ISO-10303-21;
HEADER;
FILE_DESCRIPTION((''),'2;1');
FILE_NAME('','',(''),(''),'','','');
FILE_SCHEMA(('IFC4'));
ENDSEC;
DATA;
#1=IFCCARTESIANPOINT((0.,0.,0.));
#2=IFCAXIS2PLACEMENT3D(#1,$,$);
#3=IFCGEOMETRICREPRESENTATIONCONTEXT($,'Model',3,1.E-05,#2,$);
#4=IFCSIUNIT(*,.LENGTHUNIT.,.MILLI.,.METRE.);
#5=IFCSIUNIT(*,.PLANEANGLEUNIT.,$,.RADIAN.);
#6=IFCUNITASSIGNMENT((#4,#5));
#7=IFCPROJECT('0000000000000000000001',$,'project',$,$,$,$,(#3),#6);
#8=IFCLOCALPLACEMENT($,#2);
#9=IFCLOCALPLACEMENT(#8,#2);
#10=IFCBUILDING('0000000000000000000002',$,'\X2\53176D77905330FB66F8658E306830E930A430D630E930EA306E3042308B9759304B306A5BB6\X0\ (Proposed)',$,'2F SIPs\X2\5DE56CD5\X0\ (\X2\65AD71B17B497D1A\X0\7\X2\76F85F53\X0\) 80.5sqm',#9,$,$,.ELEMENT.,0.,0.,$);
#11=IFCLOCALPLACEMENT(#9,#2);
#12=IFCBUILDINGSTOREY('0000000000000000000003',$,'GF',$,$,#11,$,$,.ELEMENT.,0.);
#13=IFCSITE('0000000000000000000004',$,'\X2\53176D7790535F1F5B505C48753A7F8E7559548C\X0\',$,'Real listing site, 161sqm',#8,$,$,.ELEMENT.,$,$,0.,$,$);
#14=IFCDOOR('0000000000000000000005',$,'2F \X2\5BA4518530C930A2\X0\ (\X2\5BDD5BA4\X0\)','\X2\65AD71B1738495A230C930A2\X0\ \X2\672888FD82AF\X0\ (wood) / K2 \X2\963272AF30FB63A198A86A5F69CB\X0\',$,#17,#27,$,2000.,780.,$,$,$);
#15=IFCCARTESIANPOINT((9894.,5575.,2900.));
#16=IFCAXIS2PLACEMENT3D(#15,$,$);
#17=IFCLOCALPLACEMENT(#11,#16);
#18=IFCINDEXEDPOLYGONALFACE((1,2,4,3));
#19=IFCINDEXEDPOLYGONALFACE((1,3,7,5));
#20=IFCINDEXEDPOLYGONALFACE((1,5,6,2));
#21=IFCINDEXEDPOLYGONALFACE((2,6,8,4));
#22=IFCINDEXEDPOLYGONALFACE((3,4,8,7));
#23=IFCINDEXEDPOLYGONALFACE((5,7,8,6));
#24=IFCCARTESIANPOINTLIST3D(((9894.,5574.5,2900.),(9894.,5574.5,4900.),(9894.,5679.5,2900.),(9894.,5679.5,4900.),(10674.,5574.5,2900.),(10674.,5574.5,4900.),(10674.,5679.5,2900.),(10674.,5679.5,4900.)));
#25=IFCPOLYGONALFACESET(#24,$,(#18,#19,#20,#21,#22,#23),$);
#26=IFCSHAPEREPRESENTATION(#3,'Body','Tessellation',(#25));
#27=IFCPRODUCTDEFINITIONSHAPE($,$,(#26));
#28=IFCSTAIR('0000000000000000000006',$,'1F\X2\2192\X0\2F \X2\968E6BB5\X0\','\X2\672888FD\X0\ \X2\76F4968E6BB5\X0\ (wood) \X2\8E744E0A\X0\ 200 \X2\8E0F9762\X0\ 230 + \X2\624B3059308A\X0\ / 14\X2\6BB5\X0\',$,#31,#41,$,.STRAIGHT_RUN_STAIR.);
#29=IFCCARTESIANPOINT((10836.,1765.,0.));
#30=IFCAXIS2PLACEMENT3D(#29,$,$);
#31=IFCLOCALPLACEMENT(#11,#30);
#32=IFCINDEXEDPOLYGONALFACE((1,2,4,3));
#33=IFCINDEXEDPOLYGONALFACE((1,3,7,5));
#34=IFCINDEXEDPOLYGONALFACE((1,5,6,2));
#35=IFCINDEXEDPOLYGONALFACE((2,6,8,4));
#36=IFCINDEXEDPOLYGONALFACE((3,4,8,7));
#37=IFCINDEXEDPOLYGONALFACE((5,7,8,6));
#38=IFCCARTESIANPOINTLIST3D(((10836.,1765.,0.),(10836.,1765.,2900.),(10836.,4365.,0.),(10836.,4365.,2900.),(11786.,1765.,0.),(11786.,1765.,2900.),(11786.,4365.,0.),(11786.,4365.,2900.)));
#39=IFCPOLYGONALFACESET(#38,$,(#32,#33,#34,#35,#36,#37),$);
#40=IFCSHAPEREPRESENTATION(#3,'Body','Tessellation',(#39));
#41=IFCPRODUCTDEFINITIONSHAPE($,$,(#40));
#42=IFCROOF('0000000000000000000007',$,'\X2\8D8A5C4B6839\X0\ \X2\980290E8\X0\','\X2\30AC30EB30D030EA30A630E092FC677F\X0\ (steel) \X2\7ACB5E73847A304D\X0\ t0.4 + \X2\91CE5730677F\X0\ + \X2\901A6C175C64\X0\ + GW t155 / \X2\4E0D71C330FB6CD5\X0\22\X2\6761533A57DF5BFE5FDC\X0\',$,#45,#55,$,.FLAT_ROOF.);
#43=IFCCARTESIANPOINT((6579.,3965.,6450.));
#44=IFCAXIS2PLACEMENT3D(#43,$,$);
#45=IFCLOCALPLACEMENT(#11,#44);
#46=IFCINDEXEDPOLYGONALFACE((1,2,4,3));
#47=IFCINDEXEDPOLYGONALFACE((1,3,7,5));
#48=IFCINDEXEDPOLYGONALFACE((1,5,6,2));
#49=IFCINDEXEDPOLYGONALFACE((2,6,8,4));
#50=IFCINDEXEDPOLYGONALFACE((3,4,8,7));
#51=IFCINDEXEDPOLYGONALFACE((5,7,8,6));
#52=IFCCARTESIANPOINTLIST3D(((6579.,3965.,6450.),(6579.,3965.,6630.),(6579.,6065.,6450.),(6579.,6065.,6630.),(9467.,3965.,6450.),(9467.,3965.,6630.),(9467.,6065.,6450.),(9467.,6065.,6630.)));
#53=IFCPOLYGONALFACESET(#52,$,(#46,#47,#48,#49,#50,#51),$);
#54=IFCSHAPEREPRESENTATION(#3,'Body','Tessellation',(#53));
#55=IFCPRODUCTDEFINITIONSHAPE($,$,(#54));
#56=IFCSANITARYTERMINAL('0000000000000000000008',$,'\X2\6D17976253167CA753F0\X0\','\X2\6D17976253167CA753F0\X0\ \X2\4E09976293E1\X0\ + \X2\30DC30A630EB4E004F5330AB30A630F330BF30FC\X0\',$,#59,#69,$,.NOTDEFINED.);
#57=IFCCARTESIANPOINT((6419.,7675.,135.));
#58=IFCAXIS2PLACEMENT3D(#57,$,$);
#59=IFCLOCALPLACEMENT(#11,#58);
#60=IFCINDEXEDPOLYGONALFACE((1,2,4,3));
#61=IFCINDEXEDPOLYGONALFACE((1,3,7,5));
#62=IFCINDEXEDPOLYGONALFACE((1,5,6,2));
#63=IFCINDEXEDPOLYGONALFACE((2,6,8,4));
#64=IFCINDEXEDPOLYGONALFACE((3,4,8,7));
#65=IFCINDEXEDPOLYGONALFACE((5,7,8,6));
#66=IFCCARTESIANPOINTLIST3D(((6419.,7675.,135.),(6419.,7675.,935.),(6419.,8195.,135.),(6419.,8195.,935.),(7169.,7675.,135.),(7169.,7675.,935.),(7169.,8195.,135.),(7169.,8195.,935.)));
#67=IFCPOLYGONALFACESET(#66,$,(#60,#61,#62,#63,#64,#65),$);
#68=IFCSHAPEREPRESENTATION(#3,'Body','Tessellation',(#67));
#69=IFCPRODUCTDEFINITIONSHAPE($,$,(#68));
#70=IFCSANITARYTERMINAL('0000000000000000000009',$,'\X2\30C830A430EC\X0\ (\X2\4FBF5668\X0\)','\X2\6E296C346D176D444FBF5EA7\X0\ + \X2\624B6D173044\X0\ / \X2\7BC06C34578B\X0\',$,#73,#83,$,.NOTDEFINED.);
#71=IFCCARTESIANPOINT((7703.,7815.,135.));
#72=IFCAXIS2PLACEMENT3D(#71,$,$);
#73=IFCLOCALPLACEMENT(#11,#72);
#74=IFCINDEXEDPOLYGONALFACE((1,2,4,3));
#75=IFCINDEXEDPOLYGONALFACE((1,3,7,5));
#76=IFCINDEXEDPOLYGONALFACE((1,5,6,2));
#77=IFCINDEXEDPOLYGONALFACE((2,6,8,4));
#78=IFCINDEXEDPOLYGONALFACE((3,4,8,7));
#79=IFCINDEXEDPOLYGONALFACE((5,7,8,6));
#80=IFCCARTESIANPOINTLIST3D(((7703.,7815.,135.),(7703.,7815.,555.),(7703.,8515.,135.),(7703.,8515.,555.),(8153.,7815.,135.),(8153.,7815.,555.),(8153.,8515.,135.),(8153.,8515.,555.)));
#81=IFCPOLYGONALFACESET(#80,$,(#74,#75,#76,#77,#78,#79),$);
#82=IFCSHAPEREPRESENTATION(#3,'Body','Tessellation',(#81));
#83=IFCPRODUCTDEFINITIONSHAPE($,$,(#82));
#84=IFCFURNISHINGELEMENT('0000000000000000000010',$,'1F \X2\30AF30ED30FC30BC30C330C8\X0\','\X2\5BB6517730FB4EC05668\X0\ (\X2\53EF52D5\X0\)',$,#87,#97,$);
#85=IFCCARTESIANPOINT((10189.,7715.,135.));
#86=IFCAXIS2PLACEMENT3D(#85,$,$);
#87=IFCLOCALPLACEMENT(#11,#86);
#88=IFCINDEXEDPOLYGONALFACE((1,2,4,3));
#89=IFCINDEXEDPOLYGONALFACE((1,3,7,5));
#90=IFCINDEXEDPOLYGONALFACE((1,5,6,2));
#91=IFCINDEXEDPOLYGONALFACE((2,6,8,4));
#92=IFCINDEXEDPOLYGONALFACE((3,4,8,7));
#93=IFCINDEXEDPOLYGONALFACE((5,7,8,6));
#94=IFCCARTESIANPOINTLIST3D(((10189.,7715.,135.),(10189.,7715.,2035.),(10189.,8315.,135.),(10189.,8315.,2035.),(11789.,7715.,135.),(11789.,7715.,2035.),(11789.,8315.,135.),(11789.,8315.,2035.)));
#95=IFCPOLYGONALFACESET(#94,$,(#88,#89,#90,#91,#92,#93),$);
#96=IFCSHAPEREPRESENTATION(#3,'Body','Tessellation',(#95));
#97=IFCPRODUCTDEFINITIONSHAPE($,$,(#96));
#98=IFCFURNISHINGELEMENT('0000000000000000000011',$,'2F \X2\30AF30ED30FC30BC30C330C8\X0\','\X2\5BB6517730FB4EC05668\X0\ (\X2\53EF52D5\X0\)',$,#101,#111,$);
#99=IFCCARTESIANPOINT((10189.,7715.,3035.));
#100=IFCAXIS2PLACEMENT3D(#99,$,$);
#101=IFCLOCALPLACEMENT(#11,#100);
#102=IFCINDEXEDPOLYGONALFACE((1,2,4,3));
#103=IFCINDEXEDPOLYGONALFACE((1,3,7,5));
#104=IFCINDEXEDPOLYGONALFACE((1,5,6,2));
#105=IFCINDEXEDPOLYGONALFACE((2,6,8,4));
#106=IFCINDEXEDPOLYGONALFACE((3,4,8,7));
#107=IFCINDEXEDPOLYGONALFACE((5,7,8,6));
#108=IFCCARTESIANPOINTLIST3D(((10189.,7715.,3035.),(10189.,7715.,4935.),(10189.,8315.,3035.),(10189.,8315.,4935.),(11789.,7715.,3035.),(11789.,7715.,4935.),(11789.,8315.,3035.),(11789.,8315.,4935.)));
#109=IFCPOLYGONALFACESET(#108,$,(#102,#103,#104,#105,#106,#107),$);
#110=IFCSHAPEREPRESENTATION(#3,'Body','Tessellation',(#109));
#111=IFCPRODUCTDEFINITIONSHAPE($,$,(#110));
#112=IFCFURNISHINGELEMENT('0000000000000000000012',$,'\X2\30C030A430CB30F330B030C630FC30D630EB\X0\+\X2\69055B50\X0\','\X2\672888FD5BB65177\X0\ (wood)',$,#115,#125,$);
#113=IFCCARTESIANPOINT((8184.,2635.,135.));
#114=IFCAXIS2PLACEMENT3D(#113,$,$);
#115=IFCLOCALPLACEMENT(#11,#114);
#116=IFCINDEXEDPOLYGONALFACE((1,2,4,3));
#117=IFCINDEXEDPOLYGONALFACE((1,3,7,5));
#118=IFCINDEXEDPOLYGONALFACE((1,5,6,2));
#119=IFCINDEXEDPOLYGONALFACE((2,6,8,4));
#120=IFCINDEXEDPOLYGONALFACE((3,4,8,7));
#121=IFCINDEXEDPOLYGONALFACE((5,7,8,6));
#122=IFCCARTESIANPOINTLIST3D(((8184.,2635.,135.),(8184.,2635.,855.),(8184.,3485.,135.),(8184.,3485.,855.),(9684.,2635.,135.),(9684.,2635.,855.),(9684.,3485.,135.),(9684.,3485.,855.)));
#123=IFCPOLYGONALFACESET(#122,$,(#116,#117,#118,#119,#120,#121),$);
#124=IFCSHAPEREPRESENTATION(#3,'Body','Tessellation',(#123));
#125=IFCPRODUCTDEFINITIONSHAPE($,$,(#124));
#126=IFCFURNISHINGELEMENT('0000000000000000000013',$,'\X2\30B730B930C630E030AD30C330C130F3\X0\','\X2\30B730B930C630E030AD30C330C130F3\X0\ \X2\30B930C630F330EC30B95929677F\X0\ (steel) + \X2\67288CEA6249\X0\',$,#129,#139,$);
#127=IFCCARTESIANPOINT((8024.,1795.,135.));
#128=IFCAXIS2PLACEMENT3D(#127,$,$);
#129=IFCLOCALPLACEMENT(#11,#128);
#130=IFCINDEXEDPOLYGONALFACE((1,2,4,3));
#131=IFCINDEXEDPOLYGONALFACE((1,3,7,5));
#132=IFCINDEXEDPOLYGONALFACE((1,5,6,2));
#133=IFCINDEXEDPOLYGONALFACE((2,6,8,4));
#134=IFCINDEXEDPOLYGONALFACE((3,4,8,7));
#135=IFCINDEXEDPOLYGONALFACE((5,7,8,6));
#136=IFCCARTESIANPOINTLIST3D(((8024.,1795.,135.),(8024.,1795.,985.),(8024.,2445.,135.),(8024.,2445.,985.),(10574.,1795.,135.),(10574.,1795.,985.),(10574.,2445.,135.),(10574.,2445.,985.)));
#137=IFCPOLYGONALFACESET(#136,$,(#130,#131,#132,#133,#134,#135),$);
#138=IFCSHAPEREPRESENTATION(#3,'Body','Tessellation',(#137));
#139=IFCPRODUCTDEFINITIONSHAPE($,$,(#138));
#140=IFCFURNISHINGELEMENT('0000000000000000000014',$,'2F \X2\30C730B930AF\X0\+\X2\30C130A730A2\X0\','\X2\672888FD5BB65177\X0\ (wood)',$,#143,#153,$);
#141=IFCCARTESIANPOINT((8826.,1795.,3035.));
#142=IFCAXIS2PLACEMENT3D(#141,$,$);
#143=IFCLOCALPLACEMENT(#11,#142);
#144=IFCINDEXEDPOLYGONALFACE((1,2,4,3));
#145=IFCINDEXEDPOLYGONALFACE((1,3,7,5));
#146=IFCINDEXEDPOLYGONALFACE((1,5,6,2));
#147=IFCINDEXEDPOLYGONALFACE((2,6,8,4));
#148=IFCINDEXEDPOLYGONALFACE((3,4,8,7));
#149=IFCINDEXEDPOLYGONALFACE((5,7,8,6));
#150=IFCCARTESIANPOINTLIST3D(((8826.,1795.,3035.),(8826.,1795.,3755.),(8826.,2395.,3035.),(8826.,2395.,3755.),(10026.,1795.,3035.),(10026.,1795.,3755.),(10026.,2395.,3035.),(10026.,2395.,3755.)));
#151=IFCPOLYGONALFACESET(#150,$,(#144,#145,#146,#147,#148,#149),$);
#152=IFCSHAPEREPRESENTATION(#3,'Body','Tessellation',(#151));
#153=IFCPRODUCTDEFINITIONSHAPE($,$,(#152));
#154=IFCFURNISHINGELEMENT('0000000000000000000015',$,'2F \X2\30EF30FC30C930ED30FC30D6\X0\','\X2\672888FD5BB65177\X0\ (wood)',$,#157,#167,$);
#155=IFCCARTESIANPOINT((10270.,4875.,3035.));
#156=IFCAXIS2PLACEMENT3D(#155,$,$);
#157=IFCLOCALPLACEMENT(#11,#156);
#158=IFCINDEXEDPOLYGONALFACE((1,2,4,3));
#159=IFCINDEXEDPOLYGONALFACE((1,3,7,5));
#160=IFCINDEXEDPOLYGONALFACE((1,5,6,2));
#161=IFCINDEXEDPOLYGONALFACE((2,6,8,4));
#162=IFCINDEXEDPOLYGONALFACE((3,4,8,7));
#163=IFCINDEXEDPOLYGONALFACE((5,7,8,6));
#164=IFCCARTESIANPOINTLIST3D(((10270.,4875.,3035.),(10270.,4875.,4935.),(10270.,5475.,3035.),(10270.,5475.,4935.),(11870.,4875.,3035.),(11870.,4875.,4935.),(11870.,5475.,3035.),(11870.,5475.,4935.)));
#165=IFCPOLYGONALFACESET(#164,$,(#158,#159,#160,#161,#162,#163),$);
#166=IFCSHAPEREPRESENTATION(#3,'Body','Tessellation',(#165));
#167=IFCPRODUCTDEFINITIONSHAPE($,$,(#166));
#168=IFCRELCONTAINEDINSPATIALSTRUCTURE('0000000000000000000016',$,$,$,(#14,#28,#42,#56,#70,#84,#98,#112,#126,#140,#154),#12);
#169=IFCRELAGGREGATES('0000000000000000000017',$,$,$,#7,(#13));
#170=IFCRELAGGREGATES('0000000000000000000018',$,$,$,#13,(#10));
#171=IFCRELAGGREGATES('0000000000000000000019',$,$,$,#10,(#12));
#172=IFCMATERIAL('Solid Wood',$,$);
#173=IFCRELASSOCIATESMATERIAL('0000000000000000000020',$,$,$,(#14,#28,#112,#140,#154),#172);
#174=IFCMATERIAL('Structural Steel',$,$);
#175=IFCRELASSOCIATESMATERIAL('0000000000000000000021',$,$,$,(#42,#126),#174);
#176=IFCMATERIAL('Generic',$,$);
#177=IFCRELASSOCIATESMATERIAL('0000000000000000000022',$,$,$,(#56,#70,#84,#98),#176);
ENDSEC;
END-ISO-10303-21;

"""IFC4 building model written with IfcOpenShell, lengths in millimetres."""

from ifc_helpers import new_model, si_unit, frame, frame_2d, origin, place, context, project, spatial, rectangle, extrude, material, element, save


model = new_model("IFC4")

# Units and contexts
model_context = context("Model", 3, precision=1e-05, world=origin())
ifc_project = project(units=[si_unit("LENGTHUNIT", "METRE", prefix="MILLI"), si_unit("PLANEANGLEUNIT", "RADIAN")], contexts=[model_context])

# Site, building, storey
site_placement = place(None, origin())
site = spatial("IfcSite", under=ifc_project, at=site_placement, Name="北海道弟子屈町美留和", ObjectType="Real listing site, 161sqm", CompositionType="ELEMENT", RefElevation=0.0)
building_placement = place(site_placement, origin())
building = spatial("IfcBuilding", under=site, at=building_placement, Name="北海道・書斎とライブラリのある静かな家 (Proposed)", ObjectType="2F SIPs工法 (断熱等級7相当) 80.5sqm", CompositionType="ELEMENT", ElevationOfRefHeight=0.0, ElevationOfTerrain=0.0)
storey_placement = place(building_placement, origin())
storey = spatial("IfcBuildingStorey", under=building, at=storey_placement, Name="GF", CompositionType="ELEMENT", Elevation=0.0)

# Shared definitions
ifc_material_1 = material(Name="Solid Wood")

# Door
door_1_placement = place(storey_placement, frame((9894.0, 5575.0, 2900.0)))
element("IfcDoor", 1, at=door_1_placement, inside=storey, material=ifc_material_1, Name="2F 室内ドア (寝室)", Description="断熱玄関ドア 木製芯 (wood) / K2 防犯・採風機構", OverallHeight=2000.0, OverallWidth=780.0, context=model_context, shape_type="SweptSolid", body=[
    extrude(rectangle(XDim=780.0, YDim=105.0, at=frame_2d((390.0, 52.0))), frame((9894.0, 5575.0, 2900.0)), (0.0, 0.0, 1.0), 2000.0),
])

# Stair
stair_placement = place(storey_placement, frame((10836.0, 1765.0, 0.0)))
element("IfcStair", 2, at=stair_placement, inside=storey, material=ifc_material_1, Name="1F→2F 階段", Description="木製 直階段 (wood) 蹴上 200 踏面 230 + 手すり / 14段", PredefinedType="STRAIGHT_RUN_STAIR", context=model_context, shape_type="SweptSolid", body=[
    extrude(rectangle(XDim=950.0, YDim=2600.0, at=frame_2d((475.0, 1300.0))), frame((10836.0, 1765.0, 0.0)), (0.0, 0.0, 1.0), 2900.0),
])

# Roof
ifc_material_2 = material(Name="Structural Steel")
roof_placement = place(storey_placement, frame((6579.0, 3965.0, 6450.0)))
element("IfcRoof", 3, at=roof_placement, inside=storey, material=ifc_material_2, Name="越屋根 頂部", Description="ガルバリウム鋼板 (steel) 立平葺き t0.4 + 野地板 + 通気層 + GW t155 / 不燃・法22条区域対応", PredefinedType="FLAT_ROOF", context=model_context, shape_type="SweptSolid", body=[
    extrude(rectangle(XDim=2888.0, YDim=2100.0, at=frame_2d((1444.0, 1050.0))), frame((6579.0, 3965.0, 6450.0)), (0.0, 0.0, 1.0), 180.0),
])

# Sanitary terminals
ifc_material_3 = material(Name="Generic")
sanitary_terminal_1_placement = place(storey_placement, frame((6419.0, 7675.0, 135.0)))
element("IfcSanitaryTerminal", 4, at=sanitary_terminal_1_placement, inside=storey, material=ifc_material_3, Name="洗面化粧台", Description="洗面化粧台 三面鏡 + ボウル一体カウンター", PredefinedType="NOTDEFINED", context=model_context, shape_type="SweptSolid", body=[
    extrude(rectangle(XDim=750.0, YDim=520.0, at=frame_2d((375.0, 260.0))), frame((6419.0, 7675.0, 135.0)), (0.0, 0.0, 1.0), 800.0),
])
sanitary_terminal_2_placement = place(storey_placement, frame((7703.0, 7815.0, 135.0)))
element("IfcSanitaryTerminal", 5, at=sanitary_terminal_2_placement, inside=storey, material=ifc_material_3, Name="トイレ (便器)", Description="温水洗浄便座 + 手洗い / 節水型", PredefinedType="NOTDEFINED", context=model_context, shape_type="SweptSolid", body=[
    extrude(rectangle(XDim=450.0, YDim=700.0, at=frame_2d((225.0, 350.0))), frame((7703.0, 7815.0, 135.0)), (0.0, 0.0, 1.0), 420.0),
])

# Furnishing elements
furnishing_1_placement = place(storey_placement, frame((10189.0, 7715.0, 135.0)))
element("IfcFurnishingElement", 6, at=furnishing_1_placement, inside=storey, material=ifc_material_3, Name="1F クローゼット", Description="家具・什器 (可動)", context=model_context, shape_type="SweptSolid", body=[
    extrude(rectangle(XDim=1600.0, YDim=600.0, at=frame_2d((800.0, 300.0))), frame((10189.0, 7715.0, 135.0)), (0.0, 0.0, 1.0), 1900.0),
])
furnishing_2_placement = place(storey_placement, frame((10189.0, 7715.0, 3035.0)))
element("IfcFurnishingElement", 7, at=furnishing_2_placement, inside=storey, material=ifc_material_3, Name="2F クローゼット", Description="家具・什器 (可動)", context=model_context, shape_type="SweptSolid", body=[
    extrude(rectangle(XDim=1600.0, YDim=600.0, at=frame_2d((800.0, 300.0))), frame((10189.0, 7715.0, 3035.0)), (0.0, 0.0, 1.0), 1900.0),
])
furnishing_3_placement = place(storey_placement, frame((8184.0, 2635.0, 135.0)))
element("IfcFurnishingElement", 8, at=furnishing_3_placement, inside=storey, material=ifc_material_1, Name="ダイニングテーブル+椅子", Description="木製家具 (wood)", context=model_context, shape_type="SweptSolid", body=[
    extrude(rectangle(XDim=1500.0, YDim=850.0, at=frame_2d((750.0, 425.0))), frame((8184.0, 2635.0, 135.0)), (0.0, 0.0, 1.0), 720.0),
])
furnishing_4_placement = place(storey_placement, frame((8024.0, 1795.0, 135.0)))
element("IfcFurnishingElement", 9, at=furnishing_4_placement, inside=storey, material=ifc_material_2, Name="システムキッチン", Description="システムキッチン ステンレス天板 (steel) + 木質扉", context=model_context, shape_type="SweptSolid", body=[
    extrude(rectangle(XDim=2550.0, YDim=650.0, at=frame_2d((1275.0, 325.0))), frame((8024.0, 1795.0, 135.0)), (0.0, 0.0, 1.0), 850.0),
])
furnishing_5_placement = place(storey_placement, frame((8826.0, 1795.0, 3035.0)))
element("IfcFurnishingElement", 10, at=furnishing_5_placement, inside=storey, material=ifc_material_1, Name="2F デスク+チェア", Description="木製家具 (wood)", context=model_context, shape_type="SweptSolid", body=[
    extrude(rectangle(XDim=1200.0, YDim=600.0, at=frame_2d((600.0, 300.0))), frame((8826.0, 1795.0, 3035.0)), (0.0, 0.0, 1.0), 720.0),
])
furnishing_6_placement = place(storey_placement, frame((10270.0, 4875.0, 3035.0)))
element("IfcFurnishingElement", 11, at=furnishing_6_placement, inside=storey, material=ifc_material_1, Name="2F ワードローブ", Description="木製家具 (wood)", context=model_context, shape_type="SweptSolid", body=[
    extrude(rectangle(XDim=1600.0, YDim=600.0, at=frame_2d((800.0, 300.0))), frame((10270.0, 4875.0, 3035.0)), (0.0, 0.0, 1.0), 1900.0),
])

save(model, "model.ifc")
